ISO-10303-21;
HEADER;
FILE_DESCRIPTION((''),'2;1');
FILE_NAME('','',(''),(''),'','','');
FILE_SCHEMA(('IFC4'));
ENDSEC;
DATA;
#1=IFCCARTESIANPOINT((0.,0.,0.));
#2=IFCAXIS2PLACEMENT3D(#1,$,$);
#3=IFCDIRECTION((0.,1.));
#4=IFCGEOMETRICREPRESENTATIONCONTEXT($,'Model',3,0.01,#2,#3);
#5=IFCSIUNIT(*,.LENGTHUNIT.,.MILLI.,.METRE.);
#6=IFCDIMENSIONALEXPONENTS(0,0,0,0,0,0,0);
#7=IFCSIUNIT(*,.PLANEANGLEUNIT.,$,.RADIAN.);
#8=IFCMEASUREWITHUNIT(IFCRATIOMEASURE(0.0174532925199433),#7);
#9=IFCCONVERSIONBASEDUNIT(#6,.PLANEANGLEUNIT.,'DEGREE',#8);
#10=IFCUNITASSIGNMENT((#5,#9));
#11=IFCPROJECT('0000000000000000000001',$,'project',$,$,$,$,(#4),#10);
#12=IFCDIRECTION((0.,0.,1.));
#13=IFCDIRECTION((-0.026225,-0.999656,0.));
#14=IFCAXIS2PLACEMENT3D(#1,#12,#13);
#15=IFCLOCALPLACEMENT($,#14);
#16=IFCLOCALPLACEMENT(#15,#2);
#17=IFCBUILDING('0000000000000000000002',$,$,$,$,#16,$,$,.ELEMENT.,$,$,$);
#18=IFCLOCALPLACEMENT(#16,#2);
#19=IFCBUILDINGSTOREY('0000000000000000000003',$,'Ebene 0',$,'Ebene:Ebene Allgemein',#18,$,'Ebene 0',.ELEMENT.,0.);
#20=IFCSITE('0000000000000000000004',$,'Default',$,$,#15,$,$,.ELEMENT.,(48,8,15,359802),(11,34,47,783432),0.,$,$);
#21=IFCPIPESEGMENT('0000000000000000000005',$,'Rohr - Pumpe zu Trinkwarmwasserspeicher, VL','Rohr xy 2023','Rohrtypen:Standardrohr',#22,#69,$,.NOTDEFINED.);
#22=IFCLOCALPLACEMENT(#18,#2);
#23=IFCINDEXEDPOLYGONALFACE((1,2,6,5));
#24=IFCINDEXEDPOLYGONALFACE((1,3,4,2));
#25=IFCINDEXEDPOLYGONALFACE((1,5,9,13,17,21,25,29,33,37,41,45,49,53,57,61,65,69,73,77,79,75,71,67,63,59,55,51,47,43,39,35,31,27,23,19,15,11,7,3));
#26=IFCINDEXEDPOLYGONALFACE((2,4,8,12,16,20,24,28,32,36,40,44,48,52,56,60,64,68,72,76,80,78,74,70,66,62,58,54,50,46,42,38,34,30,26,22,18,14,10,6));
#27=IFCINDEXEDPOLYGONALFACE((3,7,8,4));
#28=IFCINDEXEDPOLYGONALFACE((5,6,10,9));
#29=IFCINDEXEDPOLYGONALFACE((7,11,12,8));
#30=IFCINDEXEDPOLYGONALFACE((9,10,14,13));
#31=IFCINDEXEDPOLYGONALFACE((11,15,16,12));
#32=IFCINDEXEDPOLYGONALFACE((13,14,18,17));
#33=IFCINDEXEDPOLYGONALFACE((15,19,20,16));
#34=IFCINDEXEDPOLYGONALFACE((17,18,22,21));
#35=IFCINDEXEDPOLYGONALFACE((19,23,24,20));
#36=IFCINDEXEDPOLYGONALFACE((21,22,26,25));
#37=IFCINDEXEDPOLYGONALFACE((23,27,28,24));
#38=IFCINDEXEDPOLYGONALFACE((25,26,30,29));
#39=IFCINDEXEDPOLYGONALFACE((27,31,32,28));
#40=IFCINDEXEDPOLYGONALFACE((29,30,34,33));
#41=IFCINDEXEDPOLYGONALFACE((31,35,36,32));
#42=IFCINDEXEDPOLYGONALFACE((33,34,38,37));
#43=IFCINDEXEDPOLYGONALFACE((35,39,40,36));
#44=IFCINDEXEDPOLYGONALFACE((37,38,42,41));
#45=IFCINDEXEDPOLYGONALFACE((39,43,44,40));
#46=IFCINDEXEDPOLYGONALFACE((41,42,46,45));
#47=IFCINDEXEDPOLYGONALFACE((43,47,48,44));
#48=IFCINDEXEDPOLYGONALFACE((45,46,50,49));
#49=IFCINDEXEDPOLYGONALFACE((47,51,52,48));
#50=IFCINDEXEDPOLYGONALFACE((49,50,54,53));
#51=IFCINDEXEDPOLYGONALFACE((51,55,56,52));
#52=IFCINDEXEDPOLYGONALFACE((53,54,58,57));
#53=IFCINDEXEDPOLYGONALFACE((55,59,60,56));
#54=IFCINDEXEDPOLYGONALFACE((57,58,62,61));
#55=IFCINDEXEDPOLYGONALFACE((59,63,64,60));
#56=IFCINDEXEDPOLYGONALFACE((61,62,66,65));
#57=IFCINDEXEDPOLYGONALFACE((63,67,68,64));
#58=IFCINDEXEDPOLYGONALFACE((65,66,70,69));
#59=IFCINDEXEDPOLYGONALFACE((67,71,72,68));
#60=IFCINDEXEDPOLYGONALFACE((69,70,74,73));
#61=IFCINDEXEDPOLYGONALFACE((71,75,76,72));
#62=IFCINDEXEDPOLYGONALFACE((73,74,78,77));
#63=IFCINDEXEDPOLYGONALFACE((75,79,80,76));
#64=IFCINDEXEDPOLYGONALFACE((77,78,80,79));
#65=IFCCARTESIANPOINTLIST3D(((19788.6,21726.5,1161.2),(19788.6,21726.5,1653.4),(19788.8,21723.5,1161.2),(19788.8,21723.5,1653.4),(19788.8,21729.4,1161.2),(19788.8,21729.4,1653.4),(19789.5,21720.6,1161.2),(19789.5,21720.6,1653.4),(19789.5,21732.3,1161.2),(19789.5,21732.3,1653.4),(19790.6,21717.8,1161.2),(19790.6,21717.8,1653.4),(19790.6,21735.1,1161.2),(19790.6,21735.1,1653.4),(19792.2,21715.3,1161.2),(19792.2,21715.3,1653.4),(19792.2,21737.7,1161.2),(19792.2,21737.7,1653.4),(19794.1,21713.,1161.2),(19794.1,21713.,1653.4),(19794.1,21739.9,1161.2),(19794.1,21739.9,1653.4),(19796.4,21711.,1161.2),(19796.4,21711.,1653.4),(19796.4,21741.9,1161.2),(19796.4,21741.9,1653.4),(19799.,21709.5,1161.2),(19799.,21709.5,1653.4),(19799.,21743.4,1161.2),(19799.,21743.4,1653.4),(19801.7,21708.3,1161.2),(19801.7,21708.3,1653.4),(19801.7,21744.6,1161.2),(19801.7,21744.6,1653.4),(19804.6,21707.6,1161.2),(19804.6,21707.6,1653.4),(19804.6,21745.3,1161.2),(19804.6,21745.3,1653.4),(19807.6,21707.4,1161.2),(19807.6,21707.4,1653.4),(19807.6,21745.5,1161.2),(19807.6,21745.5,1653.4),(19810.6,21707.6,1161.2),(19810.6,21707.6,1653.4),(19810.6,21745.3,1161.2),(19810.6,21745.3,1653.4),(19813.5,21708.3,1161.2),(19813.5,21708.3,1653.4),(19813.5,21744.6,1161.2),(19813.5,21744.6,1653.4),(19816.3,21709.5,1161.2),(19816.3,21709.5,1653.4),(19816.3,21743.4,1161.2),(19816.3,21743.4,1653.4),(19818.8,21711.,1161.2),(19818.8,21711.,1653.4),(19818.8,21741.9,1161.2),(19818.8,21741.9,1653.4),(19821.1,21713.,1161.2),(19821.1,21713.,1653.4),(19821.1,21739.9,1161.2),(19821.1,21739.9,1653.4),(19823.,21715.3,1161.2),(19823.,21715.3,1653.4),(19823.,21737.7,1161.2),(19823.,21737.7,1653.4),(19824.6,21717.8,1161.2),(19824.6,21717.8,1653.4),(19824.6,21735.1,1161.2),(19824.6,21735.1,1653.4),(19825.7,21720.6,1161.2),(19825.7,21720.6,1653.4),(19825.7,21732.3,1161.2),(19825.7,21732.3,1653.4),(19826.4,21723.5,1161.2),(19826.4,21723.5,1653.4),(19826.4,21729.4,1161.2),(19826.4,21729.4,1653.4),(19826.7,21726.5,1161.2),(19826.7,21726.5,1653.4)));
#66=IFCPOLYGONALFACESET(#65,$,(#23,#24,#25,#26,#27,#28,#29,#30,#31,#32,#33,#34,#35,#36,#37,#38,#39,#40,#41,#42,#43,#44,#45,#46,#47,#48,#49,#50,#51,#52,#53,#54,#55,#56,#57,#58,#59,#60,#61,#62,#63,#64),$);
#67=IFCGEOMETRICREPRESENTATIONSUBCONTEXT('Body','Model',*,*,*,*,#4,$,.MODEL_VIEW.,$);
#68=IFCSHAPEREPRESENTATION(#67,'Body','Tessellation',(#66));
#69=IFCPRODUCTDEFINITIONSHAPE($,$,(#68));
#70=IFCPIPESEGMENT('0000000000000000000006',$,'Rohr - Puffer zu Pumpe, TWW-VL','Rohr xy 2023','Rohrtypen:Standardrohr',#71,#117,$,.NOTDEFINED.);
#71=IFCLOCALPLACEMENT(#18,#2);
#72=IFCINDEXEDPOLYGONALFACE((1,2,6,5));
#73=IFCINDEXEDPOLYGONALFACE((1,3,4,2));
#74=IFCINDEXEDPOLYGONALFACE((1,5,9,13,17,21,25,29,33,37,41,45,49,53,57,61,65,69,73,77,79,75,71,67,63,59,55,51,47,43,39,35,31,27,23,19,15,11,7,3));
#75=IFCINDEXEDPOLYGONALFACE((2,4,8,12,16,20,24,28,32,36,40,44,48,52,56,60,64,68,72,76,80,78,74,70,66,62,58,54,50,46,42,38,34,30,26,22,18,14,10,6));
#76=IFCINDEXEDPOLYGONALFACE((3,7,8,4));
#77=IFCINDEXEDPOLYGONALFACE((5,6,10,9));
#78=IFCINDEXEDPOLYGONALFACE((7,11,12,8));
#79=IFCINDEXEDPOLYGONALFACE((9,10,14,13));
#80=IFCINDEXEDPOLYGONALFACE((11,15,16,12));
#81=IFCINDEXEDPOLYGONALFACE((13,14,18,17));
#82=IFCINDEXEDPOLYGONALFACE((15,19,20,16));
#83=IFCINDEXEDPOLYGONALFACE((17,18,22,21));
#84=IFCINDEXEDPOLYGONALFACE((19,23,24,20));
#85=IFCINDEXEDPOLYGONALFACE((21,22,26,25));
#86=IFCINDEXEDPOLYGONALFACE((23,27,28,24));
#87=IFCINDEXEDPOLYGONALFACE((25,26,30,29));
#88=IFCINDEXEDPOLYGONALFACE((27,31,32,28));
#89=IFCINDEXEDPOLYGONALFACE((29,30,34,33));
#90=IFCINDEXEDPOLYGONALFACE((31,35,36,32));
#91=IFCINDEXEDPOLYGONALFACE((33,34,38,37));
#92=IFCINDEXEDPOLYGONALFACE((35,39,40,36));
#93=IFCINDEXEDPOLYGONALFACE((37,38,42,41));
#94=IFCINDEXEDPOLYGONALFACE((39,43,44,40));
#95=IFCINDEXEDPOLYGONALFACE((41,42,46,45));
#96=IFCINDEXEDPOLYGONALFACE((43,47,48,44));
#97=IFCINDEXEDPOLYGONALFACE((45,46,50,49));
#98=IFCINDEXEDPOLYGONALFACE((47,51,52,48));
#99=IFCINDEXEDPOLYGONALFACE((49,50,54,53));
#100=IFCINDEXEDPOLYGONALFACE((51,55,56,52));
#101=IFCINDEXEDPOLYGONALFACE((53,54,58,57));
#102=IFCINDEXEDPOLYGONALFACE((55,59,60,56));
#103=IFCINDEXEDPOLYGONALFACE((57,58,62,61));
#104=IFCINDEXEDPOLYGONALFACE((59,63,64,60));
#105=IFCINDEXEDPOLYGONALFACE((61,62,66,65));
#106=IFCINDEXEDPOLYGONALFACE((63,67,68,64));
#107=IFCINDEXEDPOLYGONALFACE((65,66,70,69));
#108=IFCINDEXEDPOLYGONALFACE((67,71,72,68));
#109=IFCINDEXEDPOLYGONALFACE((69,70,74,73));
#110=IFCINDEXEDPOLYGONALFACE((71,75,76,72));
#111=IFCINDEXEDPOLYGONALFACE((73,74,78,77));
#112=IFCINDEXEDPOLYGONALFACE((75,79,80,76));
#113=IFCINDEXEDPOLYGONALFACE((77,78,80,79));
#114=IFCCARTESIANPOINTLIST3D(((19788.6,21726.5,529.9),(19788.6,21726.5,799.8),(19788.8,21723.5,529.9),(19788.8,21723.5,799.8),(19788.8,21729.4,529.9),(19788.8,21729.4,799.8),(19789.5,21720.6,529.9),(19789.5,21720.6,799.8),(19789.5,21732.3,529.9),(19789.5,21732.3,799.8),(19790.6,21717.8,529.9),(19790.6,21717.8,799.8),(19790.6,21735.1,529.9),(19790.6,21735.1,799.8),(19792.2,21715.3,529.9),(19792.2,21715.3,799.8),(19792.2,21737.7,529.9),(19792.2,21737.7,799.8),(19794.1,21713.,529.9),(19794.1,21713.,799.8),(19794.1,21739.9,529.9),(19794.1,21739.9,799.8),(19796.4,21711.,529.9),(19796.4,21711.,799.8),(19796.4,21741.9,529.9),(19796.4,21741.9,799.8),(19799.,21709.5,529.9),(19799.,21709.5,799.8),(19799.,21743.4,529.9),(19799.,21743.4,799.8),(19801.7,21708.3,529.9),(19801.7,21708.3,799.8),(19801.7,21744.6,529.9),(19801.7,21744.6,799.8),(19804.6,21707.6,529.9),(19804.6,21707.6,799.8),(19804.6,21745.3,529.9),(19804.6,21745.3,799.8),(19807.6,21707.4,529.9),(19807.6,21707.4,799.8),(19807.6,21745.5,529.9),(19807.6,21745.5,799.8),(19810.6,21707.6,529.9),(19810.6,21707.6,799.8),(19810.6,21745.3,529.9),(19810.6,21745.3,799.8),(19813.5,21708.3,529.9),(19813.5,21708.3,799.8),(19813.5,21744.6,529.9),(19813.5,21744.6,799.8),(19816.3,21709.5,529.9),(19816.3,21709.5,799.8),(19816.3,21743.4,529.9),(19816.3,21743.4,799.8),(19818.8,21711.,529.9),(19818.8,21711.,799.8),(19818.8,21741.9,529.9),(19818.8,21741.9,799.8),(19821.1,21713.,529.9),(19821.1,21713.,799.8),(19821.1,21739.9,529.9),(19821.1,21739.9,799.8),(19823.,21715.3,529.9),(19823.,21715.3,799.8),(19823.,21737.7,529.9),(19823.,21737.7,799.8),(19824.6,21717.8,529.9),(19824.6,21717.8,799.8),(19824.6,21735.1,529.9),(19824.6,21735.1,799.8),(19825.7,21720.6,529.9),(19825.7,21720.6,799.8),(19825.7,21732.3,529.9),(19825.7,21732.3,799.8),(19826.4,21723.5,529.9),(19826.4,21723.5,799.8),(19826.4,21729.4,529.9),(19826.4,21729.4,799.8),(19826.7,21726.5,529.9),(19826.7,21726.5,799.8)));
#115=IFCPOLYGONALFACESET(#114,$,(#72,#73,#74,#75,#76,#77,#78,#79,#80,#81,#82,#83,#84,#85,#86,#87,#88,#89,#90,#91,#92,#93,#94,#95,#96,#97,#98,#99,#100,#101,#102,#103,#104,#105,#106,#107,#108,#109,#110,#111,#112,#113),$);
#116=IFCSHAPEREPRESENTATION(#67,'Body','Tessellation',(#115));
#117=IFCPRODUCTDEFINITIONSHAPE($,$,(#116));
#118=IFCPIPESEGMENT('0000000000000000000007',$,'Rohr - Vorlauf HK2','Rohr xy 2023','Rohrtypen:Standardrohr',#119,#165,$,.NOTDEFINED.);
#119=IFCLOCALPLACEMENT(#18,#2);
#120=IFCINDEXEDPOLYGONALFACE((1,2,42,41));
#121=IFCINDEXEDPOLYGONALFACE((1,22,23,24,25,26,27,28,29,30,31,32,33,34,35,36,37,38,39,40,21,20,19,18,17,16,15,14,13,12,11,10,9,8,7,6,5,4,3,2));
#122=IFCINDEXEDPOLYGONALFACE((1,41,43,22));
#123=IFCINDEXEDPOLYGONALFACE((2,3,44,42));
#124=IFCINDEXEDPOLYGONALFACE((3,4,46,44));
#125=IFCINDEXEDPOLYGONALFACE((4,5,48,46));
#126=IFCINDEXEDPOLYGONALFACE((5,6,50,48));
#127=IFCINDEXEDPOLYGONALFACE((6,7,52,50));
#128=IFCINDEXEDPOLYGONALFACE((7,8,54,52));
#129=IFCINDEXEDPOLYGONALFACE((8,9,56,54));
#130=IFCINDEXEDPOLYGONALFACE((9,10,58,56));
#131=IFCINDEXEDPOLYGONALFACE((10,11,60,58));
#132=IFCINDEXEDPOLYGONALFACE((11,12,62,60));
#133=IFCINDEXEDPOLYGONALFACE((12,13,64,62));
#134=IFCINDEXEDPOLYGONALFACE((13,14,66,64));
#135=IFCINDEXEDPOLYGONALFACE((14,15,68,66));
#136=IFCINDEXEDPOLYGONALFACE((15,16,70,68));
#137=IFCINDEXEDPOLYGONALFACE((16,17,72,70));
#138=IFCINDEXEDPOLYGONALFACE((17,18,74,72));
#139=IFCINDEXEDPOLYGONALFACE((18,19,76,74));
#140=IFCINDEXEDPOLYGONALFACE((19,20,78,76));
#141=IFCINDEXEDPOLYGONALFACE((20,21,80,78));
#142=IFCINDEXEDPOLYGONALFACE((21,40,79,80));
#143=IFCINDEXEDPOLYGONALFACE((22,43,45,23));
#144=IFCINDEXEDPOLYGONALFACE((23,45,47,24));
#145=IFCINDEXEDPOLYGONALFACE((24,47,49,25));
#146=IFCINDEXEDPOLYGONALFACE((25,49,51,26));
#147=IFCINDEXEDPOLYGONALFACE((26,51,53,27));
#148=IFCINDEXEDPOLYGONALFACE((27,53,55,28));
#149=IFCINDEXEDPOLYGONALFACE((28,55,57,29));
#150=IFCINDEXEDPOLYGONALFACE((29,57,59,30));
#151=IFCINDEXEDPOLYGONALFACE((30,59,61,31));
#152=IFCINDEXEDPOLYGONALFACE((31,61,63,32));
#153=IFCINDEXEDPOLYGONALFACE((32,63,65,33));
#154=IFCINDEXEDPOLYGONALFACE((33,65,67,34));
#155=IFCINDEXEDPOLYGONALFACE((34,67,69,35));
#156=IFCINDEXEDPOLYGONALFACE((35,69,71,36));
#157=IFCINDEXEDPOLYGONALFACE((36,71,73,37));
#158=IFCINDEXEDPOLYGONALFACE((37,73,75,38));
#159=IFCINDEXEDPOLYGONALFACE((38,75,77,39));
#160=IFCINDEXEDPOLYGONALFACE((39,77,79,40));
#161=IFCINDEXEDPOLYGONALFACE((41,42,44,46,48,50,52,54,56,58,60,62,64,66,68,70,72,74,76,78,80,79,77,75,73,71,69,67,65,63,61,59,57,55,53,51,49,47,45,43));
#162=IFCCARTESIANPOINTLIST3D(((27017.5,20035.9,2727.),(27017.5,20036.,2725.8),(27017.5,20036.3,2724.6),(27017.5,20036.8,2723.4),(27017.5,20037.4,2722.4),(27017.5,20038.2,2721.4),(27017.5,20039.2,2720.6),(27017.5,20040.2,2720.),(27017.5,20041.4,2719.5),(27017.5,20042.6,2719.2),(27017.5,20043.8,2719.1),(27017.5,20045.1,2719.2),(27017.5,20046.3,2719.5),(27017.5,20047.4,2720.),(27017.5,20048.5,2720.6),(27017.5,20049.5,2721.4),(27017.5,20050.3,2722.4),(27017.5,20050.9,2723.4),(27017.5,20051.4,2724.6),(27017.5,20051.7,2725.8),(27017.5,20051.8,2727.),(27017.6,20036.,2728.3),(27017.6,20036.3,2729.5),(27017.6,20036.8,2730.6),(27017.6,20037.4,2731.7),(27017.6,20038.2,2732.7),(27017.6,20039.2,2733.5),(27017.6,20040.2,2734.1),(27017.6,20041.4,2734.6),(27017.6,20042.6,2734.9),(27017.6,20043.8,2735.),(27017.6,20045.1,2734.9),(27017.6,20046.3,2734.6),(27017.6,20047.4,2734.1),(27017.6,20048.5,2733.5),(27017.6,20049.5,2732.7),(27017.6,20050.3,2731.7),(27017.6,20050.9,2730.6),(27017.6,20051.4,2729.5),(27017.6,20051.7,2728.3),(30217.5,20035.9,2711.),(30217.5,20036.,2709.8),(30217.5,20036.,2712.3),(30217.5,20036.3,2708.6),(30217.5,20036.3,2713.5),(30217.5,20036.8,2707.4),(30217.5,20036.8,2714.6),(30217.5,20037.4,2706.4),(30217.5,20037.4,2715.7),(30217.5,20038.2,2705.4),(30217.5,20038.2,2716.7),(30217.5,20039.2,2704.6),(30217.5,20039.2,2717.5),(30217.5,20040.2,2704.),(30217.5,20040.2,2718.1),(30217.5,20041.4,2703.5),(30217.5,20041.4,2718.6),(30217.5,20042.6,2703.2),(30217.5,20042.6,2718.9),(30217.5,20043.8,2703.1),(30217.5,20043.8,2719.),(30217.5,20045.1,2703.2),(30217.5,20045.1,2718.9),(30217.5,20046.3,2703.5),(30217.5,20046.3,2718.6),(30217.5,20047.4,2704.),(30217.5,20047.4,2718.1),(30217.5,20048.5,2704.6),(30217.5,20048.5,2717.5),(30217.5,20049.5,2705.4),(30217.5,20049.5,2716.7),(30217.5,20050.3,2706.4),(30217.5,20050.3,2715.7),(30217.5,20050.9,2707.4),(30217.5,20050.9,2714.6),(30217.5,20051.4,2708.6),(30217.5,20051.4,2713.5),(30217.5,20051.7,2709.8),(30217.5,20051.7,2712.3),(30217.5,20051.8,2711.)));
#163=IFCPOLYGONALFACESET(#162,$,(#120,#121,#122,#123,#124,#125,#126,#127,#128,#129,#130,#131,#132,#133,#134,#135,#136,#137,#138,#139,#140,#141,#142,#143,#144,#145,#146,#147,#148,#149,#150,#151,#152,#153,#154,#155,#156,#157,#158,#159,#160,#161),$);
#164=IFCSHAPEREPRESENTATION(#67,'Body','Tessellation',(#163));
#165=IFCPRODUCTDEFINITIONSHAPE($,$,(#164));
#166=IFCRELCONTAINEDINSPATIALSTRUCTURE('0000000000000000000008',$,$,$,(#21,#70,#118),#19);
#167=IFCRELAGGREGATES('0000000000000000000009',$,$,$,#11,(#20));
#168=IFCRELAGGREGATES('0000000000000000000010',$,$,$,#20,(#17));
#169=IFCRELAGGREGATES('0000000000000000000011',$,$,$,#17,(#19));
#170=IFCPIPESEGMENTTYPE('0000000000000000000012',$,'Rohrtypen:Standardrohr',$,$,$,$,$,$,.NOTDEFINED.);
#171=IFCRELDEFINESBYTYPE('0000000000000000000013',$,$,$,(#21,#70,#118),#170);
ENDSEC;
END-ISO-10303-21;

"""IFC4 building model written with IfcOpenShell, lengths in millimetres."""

from ifc_helpers import new_model, entity, si_unit, converted_unit, direction, frame, origin, place, context, subcontext, project, spatial, indexed_curve, outline, extrude, type_object, element, save


model = new_model("IFC4")

# Units and contexts
model_context = context("Model", 3, precision=0.01, world=origin(), true_north=direction((0.0, 1.0)))
body_context = subcontext(model_context, "Body", "Model", "MODEL_VIEW")
ifc_project = project(units=[si_unit("LENGTHUNIT", "METRE", prefix="MILLI"), converted_unit("PLANEANGLEUNIT", "DEGREE", entity("IfcRatioMeasure", 0.0174532925199433), si_unit("PLANEANGLEUNIT", "RADIAN"), dimensions=[0, 0, 0, 0, 0, 0, 0])], contexts=[model_context])

# Site, building, storey
site_placement = place(None, frame((0.0, 0.0, 0.0), z_axis=(0.0, 0.0, 1.0), x_axis=(-0.026225, -0.999656, 0.0)))
site = spatial("IfcSite", under=ifc_project, at=site_placement, Name="Default", CompositionType="ELEMENT", RefLatitude=(48, 8, 15, 359802), RefLongitude=(11, 34, 47, 783432), RefElevation=0.0)
building_placement = place(site_placement, origin())
building = spatial("IfcBuilding", under=site, at=building_placement, CompositionType="ELEMENT")
storey_placement = place(building_placement, origin())
storey = spatial("IfcBuildingStorey", under=building, at=storey_placement, Name="Ebene 0", ObjectType="Ebene:Ebene Allgemein", LongName="Ebene 0", CompositionType="ELEMENT", Elevation=0.0)

# Pipe segments
pipe_segment_type = type_object("IfcPipeSegmentType", Name="Rohrtypen:Standardrohr", PredefinedType="NOTDEFINED")
pipe_segment_1_placement = place(storey_placement, origin())
element("IfcPipeSegment", 1, at=pipe_segment_1_placement, inside=storey, type_object=pipe_segment_type, Name="Rohr - Pumpe zu Trinkwarmwasserspeicher, VL", Description="Rohr xy 2023", ObjectType="Rohrtypen:Standardrohr", PredefinedType="NOTDEFINED", context=body_context, shape_type="SweptSolid", body=[
    extrude(outline(indexed_curve([(19.1, 0.0), (18.8, 3.0), (18.1, 5.9), (17.0, 8.6), (15.4, 11.2), (13.5, 13.5), (11.2, 15.4), (8.6, 17.0), (5.9, 18.1), (3.0, 18.8), (0.0, 19.0), (-3.0, 18.8), (-5.9, 18.1), (-8.6, 17.0), (-11.2, 15.4), (-13.5, 13.5), (-15.4, 11.2), (-17.0, 8.6), (-18.1, 5.9), (-18.8, 3.0), (-19.1, 0.0), (-18.8, -3.0), (-18.1, -5.9), (-17.0, -8.6), (-15.4, -11.2), (-13.5, -13.5), (-11.2, -15.4), (-8.6, -17.0), (-5.9, -18.1), (-3.0, -18.8), (0.0, -19.0), (3.0, -18.8), (5.9, -18.1), (8.6, -17.0), (11.2, -15.4), (13.5, -13.5), (15.4, -11.2), (17.0, -8.6), (18.1, -5.9), (18.8, -3.0), (19.1, 0.0)], self_intersect=False)), frame((19807.6, 21726.5, 1161.2), z_axis=(0.000002, 0.000002, 1.0), x_axis=(-1.0, 0.0, 0.000002)), (0.0, 0.0, 1.0), 492.1),
])
pipe_segment_2_placement = place(storey_placement, origin())
element("IfcPipeSegment", 2, at=pipe_segment_2_placement, inside=storey, type_object=pipe_segment_type, Name="Rohr - Puffer zu Pumpe, TWW-VL", Description="Rohr xy 2023", ObjectType="Rohrtypen:Standardrohr", PredefinedType="NOTDEFINED", context=body_context, shape_type="SweptSolid", body=[
    extrude(outline(indexed_curve([(19.1, 0.0), (18.8, 3.0), (18.1, 5.9), (17.0, 8.6), (15.4, 11.2), (13.5, 13.5), (11.2, 15.4), (8.6, 17.0), (5.9, 18.1), (3.0, 18.8), (0.0, 19.0), (-3.0, 18.8), (-5.9, 18.1), (-8.6, 17.0), (-11.2, 15.4), (-13.5, 13.5), (-15.4, 11.2), (-17.0, 8.6), (-18.1, 5.9), (-18.8, 3.0), (-19.1, 0.0), (-18.8, -3.0), (-18.1, -5.9), (-17.0, -8.6), (-15.4, -11.2), (-13.5, -13.5), (-11.2, -15.4), (-8.6, -17.0), (-5.9, -18.1), (-3.0, -18.8), (0.0, -19.0), (3.0, -18.8), (5.9, -18.1), (8.6, -17.0), (11.2, -15.4), (13.5, -13.5), (15.4, -11.2), (17.0, -8.6), (18.1, -5.9), (18.8, -3.0), (19.1, 0.0)], self_intersect=False)), frame((19807.6, 21726.5, 529.9), z_axis=(0.000002, 0.000002, 1.0), x_axis=(-1.0, 0.0, 0.000002)), (0.0, 0.0, 1.0), 269.9),
])
pipe_segment_3_placement = place(storey_placement, origin())
element("IfcPipeSegment", 3, at=pipe_segment_3_placement, inside=storey, type_object=pipe_segment_type, Name="Rohr - Vorlauf HK2", Description="Rohr xy 2023", ObjectType="Rohrtypen:Standardrohr", PredefinedType="NOTDEFINED", context=body_context, shape_type="SweptSolid", body=[
    extrude(outline(indexed_curve([(7.9, 0.0), (7.8, 1.2), (7.6, 2.5), (7.1, 3.6), (6.4, 4.7), (5.6, 5.6), (4.7, 6.4), (3.6, 7.1), (2.5, 7.6), (1.2, 7.8), (0.0, 7.9), (-1.2, 7.8), (-2.5, 7.6), (-3.6, 7.1), (-4.7, 6.4), (-5.6, 5.6), (-6.4, 4.7), (-7.1, 3.6), (-7.6, 2.5), (-7.8, 1.2), (-7.9, 0.0), (-7.8, -1.2), (-7.6, -2.5), (-7.1, -3.6), (-6.4, -4.7), (-5.6, -5.6), (-4.7, -6.4), (-3.6, -7.1), (-2.5, -7.6), (-1.2, -7.8), (0.0, -7.9), (1.2, -7.8), (2.5, -7.6), (3.6, -7.1), (4.7, -6.4), (5.6, -5.6), (6.4, -4.7), (7.1, -3.6), (7.6, -2.5), (7.8, -1.2), (7.9, 0.0)], self_intersect=False)), frame((30217.5, 20043.8, 2711.0), z_axis=(-0.999988, 0.0, 0.005), x_axis=(0.0, 1.0, 0.0)), (0.0, 0.0, 1.0), 3200.0),
])

save(model, "model.ifc")
